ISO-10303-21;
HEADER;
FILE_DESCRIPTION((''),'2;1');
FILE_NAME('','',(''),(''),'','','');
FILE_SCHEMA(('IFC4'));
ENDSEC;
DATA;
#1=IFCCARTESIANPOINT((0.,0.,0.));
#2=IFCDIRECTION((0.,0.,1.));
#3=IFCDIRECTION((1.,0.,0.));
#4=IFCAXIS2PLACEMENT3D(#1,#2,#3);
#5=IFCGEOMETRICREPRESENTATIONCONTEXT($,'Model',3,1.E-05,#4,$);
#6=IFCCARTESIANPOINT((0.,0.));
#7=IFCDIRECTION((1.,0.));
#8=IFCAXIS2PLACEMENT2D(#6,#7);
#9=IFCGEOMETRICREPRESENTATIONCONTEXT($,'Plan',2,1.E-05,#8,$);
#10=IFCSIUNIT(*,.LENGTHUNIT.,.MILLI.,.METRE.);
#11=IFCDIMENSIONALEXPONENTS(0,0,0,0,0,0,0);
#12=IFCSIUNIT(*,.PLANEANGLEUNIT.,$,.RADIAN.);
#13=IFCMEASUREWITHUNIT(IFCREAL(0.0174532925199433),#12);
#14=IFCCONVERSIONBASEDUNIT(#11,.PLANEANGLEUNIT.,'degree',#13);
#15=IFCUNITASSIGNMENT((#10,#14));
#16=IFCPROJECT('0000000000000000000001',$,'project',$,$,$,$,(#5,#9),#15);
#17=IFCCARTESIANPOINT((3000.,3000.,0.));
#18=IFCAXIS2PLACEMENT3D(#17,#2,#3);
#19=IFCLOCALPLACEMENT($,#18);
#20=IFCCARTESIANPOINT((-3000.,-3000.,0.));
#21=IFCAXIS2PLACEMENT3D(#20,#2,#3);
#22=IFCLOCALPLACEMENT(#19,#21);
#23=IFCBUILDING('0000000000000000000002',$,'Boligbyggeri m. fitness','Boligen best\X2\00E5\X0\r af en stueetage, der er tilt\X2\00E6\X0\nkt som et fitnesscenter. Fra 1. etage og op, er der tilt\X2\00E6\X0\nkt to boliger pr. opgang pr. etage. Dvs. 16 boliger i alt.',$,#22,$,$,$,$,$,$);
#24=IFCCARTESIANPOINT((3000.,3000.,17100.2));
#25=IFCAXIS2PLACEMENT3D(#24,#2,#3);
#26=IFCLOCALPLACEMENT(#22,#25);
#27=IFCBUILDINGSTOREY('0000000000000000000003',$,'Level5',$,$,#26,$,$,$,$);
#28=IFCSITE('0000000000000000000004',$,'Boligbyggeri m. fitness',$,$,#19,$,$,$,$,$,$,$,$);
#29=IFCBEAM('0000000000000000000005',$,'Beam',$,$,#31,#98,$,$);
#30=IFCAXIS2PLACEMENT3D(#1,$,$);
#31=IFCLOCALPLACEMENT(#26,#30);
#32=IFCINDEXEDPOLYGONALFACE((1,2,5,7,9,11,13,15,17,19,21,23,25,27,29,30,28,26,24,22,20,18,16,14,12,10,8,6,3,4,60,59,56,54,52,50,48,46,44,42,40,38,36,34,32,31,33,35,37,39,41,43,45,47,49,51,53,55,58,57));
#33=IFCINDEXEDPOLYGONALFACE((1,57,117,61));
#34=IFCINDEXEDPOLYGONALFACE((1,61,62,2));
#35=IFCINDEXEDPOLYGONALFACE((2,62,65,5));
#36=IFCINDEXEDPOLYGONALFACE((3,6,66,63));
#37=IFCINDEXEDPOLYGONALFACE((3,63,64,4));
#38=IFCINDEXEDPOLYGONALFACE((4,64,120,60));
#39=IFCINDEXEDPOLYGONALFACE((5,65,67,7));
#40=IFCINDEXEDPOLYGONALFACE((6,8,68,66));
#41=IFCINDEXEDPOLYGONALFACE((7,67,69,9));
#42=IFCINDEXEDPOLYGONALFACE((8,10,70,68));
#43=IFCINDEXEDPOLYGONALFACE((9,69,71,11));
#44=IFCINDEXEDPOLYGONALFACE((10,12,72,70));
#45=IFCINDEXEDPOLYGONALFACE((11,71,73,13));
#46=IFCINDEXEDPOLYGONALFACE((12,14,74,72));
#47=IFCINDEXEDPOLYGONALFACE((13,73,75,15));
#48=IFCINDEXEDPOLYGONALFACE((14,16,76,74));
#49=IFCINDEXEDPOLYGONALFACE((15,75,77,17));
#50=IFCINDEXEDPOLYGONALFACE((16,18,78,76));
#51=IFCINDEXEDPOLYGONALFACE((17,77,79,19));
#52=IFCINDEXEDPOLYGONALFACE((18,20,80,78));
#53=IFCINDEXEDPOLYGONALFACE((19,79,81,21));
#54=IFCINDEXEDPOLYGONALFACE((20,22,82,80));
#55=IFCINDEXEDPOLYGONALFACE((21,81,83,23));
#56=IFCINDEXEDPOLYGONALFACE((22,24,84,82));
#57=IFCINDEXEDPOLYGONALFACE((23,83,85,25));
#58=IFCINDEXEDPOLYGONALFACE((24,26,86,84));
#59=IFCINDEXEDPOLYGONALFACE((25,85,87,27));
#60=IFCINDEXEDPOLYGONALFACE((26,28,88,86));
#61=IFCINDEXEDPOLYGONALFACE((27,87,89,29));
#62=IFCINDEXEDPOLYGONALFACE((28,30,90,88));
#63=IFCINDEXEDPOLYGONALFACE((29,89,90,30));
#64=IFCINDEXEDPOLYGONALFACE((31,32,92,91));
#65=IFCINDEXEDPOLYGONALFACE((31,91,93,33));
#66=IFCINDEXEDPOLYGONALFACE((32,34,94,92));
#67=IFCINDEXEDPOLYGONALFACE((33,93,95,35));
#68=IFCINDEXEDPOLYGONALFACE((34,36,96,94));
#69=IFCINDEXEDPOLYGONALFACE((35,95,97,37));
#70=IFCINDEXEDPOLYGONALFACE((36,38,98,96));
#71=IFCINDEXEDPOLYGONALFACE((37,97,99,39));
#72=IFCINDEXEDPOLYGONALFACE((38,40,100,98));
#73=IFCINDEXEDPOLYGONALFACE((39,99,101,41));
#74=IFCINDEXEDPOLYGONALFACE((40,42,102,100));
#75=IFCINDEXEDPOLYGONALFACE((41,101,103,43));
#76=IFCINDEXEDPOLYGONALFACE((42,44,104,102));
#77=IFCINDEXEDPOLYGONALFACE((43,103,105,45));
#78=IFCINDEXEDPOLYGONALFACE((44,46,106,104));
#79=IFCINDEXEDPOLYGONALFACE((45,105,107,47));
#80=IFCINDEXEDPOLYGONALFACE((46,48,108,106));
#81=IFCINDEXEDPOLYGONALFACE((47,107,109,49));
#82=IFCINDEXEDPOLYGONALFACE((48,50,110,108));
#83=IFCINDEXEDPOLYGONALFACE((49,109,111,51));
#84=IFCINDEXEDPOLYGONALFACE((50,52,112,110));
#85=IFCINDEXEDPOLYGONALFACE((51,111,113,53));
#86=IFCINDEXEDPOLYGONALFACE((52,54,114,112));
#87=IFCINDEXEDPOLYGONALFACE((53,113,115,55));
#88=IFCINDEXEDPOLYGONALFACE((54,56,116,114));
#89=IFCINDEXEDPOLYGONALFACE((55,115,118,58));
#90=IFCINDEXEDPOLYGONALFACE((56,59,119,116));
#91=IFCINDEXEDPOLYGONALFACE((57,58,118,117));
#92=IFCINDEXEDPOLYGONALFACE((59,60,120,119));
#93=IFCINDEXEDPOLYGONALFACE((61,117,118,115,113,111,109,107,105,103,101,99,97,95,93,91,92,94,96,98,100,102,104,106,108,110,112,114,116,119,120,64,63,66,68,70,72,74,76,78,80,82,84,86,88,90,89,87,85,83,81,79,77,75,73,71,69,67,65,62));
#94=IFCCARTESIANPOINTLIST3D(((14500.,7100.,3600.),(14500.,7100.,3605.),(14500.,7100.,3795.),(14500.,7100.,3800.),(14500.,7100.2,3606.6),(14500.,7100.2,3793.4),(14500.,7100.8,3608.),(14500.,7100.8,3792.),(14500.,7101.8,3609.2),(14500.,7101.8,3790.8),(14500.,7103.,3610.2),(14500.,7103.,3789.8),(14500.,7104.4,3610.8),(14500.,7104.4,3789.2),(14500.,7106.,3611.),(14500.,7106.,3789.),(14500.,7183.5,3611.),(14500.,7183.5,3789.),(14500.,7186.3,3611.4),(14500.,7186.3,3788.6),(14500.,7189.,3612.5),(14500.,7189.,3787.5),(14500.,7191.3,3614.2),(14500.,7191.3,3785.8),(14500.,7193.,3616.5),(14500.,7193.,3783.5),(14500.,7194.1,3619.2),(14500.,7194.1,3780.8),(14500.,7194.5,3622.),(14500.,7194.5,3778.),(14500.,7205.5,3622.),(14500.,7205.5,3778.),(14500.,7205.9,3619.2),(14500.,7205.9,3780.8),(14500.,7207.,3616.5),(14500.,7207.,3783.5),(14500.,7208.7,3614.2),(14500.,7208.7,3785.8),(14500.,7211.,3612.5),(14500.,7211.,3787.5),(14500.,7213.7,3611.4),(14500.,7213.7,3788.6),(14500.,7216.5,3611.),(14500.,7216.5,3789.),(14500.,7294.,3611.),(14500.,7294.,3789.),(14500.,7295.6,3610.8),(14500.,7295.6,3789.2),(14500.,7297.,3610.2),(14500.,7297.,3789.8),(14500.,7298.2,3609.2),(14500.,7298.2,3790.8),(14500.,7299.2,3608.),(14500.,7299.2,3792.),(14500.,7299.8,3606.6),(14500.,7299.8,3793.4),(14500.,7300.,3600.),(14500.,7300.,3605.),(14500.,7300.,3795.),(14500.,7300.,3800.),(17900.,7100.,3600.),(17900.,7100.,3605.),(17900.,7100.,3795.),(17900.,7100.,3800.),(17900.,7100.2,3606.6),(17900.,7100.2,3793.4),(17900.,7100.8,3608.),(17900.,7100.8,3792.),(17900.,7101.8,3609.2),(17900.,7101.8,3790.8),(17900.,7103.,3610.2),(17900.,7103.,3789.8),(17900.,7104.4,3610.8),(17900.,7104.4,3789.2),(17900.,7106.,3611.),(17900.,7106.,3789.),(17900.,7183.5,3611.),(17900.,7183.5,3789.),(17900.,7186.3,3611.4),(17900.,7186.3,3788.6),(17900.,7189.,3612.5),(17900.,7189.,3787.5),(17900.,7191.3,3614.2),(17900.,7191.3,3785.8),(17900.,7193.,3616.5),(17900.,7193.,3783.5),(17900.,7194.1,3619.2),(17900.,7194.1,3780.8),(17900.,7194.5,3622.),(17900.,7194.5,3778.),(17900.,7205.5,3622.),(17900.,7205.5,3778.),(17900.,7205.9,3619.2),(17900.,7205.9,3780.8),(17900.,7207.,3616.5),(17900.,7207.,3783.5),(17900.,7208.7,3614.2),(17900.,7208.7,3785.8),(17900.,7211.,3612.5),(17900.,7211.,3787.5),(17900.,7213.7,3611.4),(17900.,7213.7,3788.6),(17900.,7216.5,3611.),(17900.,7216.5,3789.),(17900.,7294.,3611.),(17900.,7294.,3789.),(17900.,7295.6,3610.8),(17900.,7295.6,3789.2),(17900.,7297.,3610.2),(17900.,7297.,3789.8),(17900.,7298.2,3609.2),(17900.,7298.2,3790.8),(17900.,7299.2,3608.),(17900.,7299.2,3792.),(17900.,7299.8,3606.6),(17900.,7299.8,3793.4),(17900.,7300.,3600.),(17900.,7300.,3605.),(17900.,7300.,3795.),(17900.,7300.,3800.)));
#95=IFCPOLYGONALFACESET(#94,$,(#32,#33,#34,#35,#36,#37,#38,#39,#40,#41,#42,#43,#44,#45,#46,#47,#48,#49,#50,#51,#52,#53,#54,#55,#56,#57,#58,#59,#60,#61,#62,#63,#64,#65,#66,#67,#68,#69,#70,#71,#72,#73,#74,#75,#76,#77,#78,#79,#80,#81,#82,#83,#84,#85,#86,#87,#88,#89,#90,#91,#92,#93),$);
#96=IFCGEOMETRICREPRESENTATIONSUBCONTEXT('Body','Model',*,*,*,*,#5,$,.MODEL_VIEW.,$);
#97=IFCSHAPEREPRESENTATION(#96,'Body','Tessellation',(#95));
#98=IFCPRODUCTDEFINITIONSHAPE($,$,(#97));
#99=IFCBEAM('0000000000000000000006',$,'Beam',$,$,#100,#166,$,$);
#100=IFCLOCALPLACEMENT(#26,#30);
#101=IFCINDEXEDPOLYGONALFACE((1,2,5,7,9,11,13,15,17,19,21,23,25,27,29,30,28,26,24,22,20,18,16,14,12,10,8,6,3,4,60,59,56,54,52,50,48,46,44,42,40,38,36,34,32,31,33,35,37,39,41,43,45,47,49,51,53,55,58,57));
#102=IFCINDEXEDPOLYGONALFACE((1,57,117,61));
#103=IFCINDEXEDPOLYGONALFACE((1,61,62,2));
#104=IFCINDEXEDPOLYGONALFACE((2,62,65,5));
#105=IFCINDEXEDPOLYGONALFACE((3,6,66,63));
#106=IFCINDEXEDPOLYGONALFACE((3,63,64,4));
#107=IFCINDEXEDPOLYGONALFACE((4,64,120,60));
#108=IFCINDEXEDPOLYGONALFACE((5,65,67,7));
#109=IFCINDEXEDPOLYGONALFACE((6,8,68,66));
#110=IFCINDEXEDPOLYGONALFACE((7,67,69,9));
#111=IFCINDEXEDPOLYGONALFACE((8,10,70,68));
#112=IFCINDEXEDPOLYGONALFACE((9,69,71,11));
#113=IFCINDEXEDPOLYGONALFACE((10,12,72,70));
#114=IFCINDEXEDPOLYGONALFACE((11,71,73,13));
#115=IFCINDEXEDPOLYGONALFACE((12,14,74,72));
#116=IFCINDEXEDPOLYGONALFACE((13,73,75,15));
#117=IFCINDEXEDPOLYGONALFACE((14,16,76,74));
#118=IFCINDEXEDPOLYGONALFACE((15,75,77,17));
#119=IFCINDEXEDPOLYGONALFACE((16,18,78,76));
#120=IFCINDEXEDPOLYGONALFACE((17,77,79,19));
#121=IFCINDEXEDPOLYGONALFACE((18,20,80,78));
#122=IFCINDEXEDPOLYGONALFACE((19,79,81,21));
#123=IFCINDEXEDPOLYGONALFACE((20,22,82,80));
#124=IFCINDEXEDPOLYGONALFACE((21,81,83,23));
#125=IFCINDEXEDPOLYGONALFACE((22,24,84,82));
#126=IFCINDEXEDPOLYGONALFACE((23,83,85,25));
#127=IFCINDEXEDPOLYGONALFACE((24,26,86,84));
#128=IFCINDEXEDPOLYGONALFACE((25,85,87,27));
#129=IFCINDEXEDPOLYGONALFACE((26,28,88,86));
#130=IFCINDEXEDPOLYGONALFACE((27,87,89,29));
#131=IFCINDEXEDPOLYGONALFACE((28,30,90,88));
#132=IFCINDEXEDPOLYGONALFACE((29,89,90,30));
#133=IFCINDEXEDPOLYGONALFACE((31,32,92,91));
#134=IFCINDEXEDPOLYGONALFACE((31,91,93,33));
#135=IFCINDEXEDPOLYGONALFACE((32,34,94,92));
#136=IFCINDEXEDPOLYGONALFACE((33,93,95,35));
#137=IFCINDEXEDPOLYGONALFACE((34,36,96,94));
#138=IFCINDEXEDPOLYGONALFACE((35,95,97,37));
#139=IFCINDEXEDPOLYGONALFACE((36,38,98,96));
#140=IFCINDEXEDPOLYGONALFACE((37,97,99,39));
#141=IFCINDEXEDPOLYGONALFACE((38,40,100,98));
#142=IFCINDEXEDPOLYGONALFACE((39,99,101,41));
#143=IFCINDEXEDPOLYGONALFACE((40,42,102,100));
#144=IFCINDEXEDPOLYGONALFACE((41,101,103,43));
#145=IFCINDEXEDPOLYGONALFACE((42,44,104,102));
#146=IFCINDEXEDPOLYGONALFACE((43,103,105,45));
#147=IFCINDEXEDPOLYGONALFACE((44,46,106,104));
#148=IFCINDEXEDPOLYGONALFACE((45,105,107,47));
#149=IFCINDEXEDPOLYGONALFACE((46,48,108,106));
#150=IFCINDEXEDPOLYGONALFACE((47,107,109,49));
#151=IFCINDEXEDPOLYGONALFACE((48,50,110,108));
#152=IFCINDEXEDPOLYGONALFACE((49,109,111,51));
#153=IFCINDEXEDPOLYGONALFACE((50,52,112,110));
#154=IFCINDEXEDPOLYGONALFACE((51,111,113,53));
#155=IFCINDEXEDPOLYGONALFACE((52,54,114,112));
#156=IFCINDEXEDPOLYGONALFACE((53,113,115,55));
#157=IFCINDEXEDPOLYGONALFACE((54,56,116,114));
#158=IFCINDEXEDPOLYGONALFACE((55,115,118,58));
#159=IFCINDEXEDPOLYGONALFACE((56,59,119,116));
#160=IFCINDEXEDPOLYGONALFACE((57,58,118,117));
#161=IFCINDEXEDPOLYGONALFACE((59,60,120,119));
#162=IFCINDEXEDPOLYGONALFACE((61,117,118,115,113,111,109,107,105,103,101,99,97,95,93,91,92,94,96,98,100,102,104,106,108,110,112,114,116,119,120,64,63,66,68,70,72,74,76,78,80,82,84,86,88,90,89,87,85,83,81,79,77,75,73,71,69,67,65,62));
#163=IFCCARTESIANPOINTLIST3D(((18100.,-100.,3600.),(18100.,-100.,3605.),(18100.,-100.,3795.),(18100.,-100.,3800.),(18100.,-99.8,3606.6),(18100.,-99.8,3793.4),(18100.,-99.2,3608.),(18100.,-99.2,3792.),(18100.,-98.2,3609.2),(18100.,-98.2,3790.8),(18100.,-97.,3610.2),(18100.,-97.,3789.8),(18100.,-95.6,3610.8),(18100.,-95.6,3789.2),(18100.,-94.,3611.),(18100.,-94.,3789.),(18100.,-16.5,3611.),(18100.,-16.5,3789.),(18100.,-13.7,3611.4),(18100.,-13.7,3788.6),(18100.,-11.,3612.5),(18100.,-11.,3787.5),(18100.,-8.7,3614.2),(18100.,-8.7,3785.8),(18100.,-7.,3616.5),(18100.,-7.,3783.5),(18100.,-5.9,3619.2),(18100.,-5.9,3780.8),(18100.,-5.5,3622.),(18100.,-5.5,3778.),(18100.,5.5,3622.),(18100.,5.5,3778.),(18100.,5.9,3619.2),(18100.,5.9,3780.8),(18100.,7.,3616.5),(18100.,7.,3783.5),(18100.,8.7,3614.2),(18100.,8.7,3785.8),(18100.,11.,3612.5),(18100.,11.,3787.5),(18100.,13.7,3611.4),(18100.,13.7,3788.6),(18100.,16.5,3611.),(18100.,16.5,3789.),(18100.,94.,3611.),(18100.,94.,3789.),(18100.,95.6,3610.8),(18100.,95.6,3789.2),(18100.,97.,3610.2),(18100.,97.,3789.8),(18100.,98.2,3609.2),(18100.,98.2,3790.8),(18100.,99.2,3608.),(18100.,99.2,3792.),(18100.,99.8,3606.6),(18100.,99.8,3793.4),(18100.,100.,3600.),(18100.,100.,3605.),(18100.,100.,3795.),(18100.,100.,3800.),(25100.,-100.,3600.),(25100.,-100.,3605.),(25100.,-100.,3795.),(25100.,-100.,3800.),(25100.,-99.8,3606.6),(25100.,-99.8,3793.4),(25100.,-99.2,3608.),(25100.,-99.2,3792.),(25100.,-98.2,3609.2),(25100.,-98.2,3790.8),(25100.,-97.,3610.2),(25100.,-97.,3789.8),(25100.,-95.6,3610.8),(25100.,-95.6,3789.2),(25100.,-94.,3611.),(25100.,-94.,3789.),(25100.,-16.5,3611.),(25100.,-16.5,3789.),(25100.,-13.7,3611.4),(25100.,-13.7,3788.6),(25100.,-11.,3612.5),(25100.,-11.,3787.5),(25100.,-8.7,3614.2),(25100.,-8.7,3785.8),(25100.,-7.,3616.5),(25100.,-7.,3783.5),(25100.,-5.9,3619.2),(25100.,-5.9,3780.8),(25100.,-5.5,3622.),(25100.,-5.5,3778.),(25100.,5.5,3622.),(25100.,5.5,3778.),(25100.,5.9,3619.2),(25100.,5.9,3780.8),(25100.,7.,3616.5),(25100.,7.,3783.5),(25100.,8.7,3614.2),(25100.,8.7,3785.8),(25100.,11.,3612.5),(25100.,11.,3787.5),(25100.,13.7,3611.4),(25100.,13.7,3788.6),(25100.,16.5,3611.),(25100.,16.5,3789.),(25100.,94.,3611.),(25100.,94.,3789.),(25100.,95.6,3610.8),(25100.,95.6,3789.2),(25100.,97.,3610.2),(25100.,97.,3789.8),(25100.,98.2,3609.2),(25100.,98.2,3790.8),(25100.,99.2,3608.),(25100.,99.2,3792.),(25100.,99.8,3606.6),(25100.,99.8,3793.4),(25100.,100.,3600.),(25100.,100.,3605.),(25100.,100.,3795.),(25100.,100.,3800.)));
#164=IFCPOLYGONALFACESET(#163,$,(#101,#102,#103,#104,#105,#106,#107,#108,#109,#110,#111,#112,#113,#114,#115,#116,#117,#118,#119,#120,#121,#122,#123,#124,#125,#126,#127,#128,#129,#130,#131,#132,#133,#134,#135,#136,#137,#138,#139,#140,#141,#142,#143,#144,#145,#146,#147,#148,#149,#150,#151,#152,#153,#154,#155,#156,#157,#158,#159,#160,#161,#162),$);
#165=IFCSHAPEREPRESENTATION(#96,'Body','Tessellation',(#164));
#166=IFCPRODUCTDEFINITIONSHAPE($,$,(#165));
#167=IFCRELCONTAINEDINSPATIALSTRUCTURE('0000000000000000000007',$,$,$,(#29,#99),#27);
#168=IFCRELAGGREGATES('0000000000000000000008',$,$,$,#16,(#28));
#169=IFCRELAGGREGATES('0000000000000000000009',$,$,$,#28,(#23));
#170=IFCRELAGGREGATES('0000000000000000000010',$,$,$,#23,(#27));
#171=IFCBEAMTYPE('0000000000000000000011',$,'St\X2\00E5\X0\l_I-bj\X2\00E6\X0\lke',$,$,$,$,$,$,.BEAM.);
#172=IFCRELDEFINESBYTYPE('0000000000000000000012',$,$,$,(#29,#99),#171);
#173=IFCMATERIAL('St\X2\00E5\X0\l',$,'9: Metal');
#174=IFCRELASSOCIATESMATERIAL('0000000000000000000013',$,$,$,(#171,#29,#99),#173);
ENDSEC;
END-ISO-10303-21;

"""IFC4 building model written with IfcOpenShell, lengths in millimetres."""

from ifc_helpers import new_model, entity, si_unit, converted_unit, frame, origin_with_axes, origin_2d_with_axis, place, context, subcontext, project, spatial, i_section, extrude, material, material_profile, profile_set, profile_usage, type_object, element, save


model = new_model("IFC4")

# Units and contexts
model_context = context("Model", 3, precision=1e-05, world=origin_with_axes())
plan_context = context("Plan", 2, precision=1e-05, world=origin_2d_with_axis())
body_context = subcontext(model_context, "Body", "Model", "MODEL_VIEW")
ifc_project = project(units=[si_unit("LENGTHUNIT", "METRE", prefix="MILLI"), converted_unit("PLANEANGLEUNIT", "degree", entity("IfcReal", 0.0174532925199433), si_unit("PLANEANGLEUNIT", "RADIAN"), dimensions=[0, 0, 0, 0, 0, 0, 0])], contexts=[model_context, plan_context])

# Site, building, storey
site_placement = place(None, frame((3000.0, 3000.0, 0.0), z_axis=(0.0, 0.0, 1.0), x_axis=(1.0, 0.0, 0.0)))
site = spatial("IfcSite", under=ifc_project, at=site_placement, Name="Boligbyggeri m. fitness")
building_placement = place(site_placement, frame((-3000.0, -3000.0, 0.0), z_axis=(0.0, 0.0, 1.0), x_axis=(1.0, 0.0, 0.0)))
building = spatial("IfcBuilding", under=site, at=building_placement, Name="Boligbyggeri m. fitness", Description="Boligen består af en stueetage, der er tiltænkt som et fitnesscenter. Fra 1. etage og op, er der tiltænkt to boliger pr. opgang pr. etage. Dvs. 16 boliger i alt.")
storey_placement = place(building_placement, frame((3000.0, 3000.0, 17100.2), z_axis=(0.0, 0.0, 1.0), x_axis=(1.0, 0.0, 0.0)))
storey = spatial("IfcBuildingStorey", under=building, at=storey_placement, Name="Level5")

# Beams
ifc_material_1 = material(Name="Stål", Category="9: Metal")
ifc_material_profile_1 = material_profile(ifc_material_1, i_section(OverallWidth=200.0, OverallDepth=200.0, WebThickness=11.0, FlangeThickness=11.0, FilletRadius=11.0, FlangeEdgeRadius=6.0), Name="Stål", Category="9: Metal")
ifc_profile_set_1 = profile_set([ifc_material_profile_1], Name="NY_I-Profil")
beam_type = type_object("IfcBeamType", Name="Stål_I-bjælke", PredefinedType="BEAM", material=ifc_profile_set_1)
ifc_profile_usage_1 = profile_usage(ifc_profile_set_1, cardinal=7)
beam_1_placement = place(storey_placement, frame((14500.0, 7300.0, 3800.0), z_axis=(1.0, 0.0, 0.0), x_axis=(0.0, 1.0, 0.0)))
element("IfcBeam", 1, at=beam_1_placement, inside=storey, type_object=beam_type, material=ifc_profile_usage_1, Name="Beam", context=body_context, shape_type="SweptSolid", body=[
    extrude(i_section(OverallWidth=200.0, OverallDepth=200.0, WebThickness=11.0, FlangeThickness=11.0, FilletRadius=11.0, FlangeEdgeRadius=6.0), frame((-100.0, -100.0, 0.0), z_axis=(0.0, 0.0, 1.0), x_axis=(1.0, 0.0, 0.0)), (0.0, 0.0, 1.0), 3400.0),
])
ifc_profile_usage_2 = profile_usage(ifc_profile_set_1, cardinal=7)
beam_2_placement = place(storey_placement, frame((18100.0, 100.0, 3800.0), z_axis=(1.0, 0.0, 0.0), x_axis=(0.0, 1.0, 0.0)))
element("IfcBeam", 2, at=beam_2_placement, inside=storey, type_object=beam_type, material=ifc_profile_usage_2, Name="Beam", context=body_context, shape_type="SweptSolid", body=[
    extrude(i_section(OverallWidth=200.0, OverallDepth=200.0, WebThickness=11.0, FlangeThickness=11.0, FilletRadius=11.0, FlangeEdgeRadius=6.0), frame((-100.0, -100.0, 0.0), z_axis=(0.0, 0.0, 1.0), x_axis=(1.0, 0.0, 0.0)), (0.0, 0.0, 1.0), 7000.0),
])

save(model, "model.ifc")
